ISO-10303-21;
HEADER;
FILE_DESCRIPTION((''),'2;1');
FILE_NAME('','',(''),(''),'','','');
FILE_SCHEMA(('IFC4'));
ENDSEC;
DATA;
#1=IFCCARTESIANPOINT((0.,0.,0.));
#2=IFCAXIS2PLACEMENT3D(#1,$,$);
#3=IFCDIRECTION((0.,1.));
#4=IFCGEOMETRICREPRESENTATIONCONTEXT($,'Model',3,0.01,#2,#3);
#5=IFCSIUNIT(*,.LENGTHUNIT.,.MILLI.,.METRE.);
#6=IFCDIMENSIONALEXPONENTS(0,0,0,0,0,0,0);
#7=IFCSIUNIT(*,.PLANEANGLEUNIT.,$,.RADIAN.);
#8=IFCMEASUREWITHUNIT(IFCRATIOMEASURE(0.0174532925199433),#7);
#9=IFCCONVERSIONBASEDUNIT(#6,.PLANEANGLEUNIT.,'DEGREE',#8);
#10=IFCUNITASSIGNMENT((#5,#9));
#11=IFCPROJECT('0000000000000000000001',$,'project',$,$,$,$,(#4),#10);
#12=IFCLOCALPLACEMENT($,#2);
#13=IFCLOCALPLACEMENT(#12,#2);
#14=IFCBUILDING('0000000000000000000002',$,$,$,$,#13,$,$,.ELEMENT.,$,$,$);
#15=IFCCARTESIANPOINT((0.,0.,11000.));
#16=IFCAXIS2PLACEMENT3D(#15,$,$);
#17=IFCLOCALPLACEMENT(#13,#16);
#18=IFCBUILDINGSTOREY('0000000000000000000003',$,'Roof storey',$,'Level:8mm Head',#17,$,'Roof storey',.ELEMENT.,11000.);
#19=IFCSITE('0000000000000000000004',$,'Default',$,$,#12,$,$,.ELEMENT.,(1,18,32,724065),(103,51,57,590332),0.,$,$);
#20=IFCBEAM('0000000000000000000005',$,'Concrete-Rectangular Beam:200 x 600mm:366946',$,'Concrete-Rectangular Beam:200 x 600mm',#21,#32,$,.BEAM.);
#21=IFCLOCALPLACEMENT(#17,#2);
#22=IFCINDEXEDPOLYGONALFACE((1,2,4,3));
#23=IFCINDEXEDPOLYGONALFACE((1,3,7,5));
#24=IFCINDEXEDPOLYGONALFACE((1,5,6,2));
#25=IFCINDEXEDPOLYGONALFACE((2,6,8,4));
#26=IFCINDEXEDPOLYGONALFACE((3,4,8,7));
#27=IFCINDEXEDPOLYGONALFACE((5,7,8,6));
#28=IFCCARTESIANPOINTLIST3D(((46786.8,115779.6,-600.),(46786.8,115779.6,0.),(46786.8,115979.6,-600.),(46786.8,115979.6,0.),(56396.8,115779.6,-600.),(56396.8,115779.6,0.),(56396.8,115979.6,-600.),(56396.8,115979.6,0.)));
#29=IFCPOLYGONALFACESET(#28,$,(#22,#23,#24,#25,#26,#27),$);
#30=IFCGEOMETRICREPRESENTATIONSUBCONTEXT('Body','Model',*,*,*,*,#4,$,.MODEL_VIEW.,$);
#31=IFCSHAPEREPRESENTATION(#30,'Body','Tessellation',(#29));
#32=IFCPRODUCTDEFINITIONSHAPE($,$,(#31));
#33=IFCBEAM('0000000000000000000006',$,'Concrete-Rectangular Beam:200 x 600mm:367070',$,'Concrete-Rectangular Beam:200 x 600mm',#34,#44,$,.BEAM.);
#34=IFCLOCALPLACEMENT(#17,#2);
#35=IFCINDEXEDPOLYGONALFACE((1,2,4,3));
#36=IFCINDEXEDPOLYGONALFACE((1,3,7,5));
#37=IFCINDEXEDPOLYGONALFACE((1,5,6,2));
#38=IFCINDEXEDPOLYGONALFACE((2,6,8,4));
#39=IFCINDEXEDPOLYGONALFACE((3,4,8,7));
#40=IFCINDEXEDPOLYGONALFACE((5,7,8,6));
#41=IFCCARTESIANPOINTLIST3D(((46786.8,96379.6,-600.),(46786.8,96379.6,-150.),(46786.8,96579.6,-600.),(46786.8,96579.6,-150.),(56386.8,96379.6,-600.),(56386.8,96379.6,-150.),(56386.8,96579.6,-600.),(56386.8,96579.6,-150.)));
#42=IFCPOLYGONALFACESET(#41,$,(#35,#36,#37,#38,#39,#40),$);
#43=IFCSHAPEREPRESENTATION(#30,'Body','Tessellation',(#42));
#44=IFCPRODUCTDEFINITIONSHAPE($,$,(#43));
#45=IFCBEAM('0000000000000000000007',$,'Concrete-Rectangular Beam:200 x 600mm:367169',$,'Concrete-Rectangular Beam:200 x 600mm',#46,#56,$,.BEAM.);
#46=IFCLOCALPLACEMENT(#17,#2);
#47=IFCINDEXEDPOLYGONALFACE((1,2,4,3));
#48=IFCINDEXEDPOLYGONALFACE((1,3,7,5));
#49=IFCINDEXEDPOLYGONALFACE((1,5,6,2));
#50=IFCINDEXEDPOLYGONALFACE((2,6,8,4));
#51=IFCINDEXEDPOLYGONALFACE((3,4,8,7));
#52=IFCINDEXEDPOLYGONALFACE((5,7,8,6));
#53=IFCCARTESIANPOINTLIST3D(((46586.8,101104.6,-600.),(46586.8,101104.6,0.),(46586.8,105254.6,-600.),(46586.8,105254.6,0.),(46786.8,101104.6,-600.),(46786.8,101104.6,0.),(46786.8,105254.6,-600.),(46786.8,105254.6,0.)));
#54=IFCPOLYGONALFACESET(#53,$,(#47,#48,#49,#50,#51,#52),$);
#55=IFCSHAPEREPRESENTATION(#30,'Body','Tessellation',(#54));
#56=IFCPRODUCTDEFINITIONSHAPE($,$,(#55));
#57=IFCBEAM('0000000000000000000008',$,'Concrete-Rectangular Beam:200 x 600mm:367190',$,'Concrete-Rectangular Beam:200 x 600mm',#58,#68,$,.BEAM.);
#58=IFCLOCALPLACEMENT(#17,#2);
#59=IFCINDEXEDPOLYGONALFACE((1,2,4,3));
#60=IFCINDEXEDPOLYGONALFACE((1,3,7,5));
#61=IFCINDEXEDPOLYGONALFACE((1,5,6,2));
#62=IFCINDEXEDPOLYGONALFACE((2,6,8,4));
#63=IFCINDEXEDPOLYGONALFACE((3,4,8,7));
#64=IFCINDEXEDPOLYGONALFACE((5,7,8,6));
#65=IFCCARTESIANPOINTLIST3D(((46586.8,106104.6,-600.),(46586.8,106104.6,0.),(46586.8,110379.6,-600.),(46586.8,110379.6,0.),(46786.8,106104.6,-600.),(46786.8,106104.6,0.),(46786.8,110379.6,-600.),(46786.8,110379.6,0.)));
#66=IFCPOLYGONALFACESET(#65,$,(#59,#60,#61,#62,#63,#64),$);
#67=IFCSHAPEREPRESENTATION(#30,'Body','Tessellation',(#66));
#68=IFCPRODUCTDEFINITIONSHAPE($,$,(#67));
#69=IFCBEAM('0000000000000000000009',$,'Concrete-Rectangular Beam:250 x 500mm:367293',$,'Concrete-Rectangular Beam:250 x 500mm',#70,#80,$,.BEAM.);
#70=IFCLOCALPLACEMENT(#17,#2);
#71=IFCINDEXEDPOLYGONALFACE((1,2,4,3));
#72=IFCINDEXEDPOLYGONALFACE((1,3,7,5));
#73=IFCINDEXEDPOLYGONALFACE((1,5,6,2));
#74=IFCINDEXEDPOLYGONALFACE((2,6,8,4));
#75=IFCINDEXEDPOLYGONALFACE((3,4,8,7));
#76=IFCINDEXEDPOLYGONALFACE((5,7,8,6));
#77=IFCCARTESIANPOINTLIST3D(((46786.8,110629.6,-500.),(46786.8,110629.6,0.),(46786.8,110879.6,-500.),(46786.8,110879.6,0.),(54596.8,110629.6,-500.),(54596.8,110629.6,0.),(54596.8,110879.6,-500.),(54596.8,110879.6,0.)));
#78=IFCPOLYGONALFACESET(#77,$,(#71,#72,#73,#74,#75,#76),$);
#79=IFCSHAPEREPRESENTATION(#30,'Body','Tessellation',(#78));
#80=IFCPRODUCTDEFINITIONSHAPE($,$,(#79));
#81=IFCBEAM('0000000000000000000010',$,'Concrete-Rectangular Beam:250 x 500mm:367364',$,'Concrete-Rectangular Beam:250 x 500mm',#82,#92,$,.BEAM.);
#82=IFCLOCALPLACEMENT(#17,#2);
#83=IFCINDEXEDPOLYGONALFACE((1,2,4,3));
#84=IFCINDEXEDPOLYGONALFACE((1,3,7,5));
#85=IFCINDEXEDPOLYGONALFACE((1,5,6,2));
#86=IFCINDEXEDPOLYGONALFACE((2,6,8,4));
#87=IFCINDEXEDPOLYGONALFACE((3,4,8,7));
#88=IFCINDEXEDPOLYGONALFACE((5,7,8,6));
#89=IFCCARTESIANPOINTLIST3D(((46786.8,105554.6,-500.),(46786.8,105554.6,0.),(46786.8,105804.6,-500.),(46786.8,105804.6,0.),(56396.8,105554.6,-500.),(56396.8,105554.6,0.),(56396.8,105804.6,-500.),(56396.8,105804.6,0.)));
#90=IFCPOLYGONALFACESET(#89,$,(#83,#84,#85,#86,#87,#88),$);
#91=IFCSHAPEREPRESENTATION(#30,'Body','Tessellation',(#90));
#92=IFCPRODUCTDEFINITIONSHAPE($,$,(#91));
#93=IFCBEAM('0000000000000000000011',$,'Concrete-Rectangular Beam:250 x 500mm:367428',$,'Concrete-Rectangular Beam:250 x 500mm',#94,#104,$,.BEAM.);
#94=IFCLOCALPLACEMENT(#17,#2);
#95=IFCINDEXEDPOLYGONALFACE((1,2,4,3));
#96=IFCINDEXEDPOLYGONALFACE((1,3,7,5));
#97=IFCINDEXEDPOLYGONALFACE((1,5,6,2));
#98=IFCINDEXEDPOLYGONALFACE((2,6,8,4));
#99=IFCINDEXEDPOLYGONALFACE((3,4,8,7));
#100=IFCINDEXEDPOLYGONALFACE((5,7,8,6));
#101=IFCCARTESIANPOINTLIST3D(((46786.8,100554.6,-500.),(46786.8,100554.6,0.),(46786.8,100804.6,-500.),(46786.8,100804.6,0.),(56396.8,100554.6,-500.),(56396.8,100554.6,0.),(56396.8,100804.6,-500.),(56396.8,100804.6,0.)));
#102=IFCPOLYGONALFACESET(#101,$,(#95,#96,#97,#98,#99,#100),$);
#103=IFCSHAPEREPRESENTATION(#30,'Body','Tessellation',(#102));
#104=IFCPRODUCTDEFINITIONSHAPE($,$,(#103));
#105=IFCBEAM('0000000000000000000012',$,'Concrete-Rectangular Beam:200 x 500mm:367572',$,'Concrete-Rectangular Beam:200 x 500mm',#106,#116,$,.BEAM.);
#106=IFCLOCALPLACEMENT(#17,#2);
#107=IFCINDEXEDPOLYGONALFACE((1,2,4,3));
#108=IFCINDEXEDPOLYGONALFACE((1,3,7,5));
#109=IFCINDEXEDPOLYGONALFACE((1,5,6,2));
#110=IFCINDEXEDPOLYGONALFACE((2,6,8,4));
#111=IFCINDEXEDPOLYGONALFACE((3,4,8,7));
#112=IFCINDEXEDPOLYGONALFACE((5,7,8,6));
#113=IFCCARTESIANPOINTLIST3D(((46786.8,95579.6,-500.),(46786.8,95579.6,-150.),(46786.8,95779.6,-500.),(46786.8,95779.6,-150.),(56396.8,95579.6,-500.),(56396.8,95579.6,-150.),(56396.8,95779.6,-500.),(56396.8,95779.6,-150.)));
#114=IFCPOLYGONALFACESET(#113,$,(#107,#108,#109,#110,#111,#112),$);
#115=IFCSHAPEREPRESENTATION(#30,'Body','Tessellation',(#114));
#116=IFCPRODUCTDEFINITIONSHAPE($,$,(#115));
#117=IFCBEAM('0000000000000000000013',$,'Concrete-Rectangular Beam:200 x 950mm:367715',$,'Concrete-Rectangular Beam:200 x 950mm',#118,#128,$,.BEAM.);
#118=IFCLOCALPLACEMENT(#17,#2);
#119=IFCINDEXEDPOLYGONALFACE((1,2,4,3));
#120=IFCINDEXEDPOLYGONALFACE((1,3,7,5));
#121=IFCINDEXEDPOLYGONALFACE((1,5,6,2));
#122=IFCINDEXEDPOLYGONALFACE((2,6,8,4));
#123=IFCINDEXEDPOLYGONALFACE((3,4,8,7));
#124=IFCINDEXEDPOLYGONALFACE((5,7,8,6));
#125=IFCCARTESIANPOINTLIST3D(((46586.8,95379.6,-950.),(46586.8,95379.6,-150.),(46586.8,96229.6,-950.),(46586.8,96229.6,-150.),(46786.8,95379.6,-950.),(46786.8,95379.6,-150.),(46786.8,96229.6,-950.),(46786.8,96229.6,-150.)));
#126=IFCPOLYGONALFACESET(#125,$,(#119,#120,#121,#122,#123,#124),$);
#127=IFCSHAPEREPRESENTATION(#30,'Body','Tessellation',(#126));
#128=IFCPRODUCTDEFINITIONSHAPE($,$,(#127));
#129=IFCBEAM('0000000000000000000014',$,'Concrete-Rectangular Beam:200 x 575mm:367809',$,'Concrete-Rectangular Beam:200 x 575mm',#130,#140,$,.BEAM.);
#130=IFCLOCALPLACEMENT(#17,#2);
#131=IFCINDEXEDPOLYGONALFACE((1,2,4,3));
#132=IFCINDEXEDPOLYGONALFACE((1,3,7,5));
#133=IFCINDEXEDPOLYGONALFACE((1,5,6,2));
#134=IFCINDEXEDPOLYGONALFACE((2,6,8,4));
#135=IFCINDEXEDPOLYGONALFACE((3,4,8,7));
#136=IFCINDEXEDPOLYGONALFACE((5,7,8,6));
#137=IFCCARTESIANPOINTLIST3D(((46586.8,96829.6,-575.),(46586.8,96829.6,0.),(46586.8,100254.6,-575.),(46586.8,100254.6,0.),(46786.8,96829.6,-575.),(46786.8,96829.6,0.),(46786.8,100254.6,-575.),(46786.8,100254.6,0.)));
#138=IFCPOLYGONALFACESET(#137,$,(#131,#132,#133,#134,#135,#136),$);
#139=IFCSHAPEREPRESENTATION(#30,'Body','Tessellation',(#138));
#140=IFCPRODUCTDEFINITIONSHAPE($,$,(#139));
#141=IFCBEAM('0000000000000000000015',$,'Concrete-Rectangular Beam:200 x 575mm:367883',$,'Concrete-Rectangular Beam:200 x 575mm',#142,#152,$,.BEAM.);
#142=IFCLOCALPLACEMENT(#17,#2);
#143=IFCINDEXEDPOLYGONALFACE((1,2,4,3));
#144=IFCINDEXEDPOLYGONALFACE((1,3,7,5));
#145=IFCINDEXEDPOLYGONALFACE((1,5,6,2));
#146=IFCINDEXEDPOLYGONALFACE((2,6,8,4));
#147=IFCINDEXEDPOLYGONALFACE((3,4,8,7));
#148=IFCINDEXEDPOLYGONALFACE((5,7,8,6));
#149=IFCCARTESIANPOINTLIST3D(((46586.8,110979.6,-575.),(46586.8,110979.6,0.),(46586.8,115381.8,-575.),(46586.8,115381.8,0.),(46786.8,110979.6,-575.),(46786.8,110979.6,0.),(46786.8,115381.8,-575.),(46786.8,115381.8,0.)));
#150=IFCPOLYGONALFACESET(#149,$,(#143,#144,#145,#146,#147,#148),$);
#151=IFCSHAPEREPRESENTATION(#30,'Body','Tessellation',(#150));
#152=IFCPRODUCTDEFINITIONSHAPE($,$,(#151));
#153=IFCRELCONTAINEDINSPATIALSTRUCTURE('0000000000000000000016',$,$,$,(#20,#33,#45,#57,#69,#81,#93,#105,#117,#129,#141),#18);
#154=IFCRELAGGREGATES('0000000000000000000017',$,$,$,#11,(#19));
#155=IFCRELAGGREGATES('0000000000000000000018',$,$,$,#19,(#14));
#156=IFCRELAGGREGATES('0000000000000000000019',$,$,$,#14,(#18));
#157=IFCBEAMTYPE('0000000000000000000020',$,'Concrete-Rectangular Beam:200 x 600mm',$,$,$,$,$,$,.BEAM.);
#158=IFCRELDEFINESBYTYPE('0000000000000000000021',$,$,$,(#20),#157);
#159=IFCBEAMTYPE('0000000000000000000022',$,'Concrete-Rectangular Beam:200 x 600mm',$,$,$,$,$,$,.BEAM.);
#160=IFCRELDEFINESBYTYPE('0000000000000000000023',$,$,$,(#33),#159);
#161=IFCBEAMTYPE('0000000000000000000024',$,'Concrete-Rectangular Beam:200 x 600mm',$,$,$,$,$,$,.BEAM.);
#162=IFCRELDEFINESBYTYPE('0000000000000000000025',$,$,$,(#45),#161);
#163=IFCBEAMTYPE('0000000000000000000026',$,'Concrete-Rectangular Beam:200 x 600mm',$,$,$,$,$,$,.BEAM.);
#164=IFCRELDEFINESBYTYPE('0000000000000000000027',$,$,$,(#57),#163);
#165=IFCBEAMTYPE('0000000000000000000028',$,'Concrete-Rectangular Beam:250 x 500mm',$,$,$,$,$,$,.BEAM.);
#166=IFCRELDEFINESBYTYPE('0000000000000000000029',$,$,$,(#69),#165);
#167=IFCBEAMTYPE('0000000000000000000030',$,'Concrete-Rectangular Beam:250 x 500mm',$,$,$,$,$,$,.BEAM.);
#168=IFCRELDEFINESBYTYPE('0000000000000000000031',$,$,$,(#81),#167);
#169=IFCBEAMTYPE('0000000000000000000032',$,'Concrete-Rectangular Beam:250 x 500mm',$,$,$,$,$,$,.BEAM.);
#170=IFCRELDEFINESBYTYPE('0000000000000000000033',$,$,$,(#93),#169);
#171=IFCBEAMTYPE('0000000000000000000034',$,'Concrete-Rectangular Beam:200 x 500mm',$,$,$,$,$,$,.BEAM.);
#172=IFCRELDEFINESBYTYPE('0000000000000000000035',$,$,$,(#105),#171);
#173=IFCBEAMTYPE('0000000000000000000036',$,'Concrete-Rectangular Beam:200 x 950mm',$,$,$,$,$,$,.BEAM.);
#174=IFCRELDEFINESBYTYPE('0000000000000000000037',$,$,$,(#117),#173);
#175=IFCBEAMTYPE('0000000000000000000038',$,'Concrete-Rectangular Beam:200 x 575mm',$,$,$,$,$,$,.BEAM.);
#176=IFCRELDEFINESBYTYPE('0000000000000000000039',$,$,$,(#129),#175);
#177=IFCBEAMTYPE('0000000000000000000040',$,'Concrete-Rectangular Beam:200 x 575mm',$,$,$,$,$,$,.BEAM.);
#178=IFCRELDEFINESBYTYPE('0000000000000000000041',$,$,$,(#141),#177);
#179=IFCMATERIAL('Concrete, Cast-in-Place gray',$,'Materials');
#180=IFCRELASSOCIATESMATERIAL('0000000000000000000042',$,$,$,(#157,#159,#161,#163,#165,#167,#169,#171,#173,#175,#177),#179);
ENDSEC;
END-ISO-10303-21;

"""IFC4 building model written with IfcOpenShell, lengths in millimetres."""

from ifc_helpers import new_model, entity, si_unit, converted_unit, direction, frame, origin, place, context, subcontext, project, spatial, indexed_curve, outline, extrude, source, transform, mapped, material, type_object, type_shapes, element, save


model = new_model("IFC4")

# Units and contexts
model_context = context("Model", 3, precision=0.01, world=origin(), true_north=direction((0.0, 1.0)))
body_context = subcontext(model_context, "Body", "Model", "MODEL_VIEW")
ifc_project = project(units=[si_unit("LENGTHUNIT", "METRE", prefix="MILLI"), converted_unit("PLANEANGLEUNIT", "DEGREE", entity("IfcRatioMeasure", 0.0174532925199433), si_unit("PLANEANGLEUNIT", "RADIAN"), dimensions=[0, 0, 0, 0, 0, 0, 0])], contexts=[model_context])

# Site, building, storey
site_placement = place(None, origin())
site = spatial("IfcSite", under=ifc_project, at=site_placement, Name="Default", CompositionType="ELEMENT", RefLatitude=(1, 18, 32, 724065), RefLongitude=(103, 51, 57, 590332), RefElevation=0.0)
building_placement = place(site_placement, origin())
building = spatial("IfcBuilding", under=site, at=building_placement, CompositionType="ELEMENT")
storey_placement = place(building_placement, frame((0.0, 0.0, 11000.0)))
storey = spatial("IfcBuildingStorey", under=building, at=storey_placement, Name="Roof storey", ObjectType="Level:8mm Head", LongName="Roof storey", CompositionType="ELEMENT", Elevation=11000.0)

# Beams
ifc_material_1 = material(Name="Concrete, Cast-in-Place gray", Category="Materials")
beam_type_1 = type_object("IfcBeamType", Name="Concrete-Rectangular Beam:200 x 600mm", PredefinedType="BEAM", material=ifc_material_1)
shared_shape_1 = source(origin(), body_context, "Body", "SweptSolid", [
    extrude(outline(indexed_curve([(-300.0, -100.0), (300.0, -100.0), (300.0, 100.0), (-300.0, 100.0), (-300.0, -100.0)], self_intersect=False)), frame((46786.8, 115879.6, 10700.0), z_axis=(1.0, 0.0, 0.0), x_axis=(0.0, 0.0, -1.0)), (0.0, 0.0, 1.0), 9610.0),
])
type_shapes(beam_type_1, [shared_shape_1])
beam_1_placement = place(storey_placement, frame((0.0, 0.0, -11000.0)))
element("IfcBeam", 1, at=beam_1_placement, inside=storey, type_object=beam_type_1, Name="Concrete-Rectangular Beam:200 x 600mm:366946", ObjectType="Concrete-Rectangular Beam:200 x 600mm", PredefinedType="BEAM", context=body_context, shape_type="MappedRepresentation", body=[
    mapped(shared_shape_1, transform((0.0, 0.0, 0.0), scale=1.0)),
])
beam_type_2 = type_object("IfcBeamType", Name="Concrete-Rectangular Beam:200 x 600mm", PredefinedType="BEAM", material=ifc_material_1)
shared_shape_2 = source(origin(), body_context, "Body", "SweptSolid", [
    extrude(outline(indexed_curve([(-225.0, -100.0), (225.0, -100.0), (225.0, 100.0), (-225.0, 100.0), (-225.0, -100.0)], self_intersect=False)), frame((46786.8, 96479.6, 10625.0), z_axis=(1.0, 0.0, 0.0), x_axis=(0.0, 0.0, -1.0)), (0.0, 0.0, 1.0), 9600.0),
])
type_shapes(beam_type_2, [shared_shape_2])
beam_2_placement = place(storey_placement, frame((0.0, 0.0, -11000.0)))
element("IfcBeam", 2, at=beam_2_placement, inside=storey, type_object=beam_type_2, Name="Concrete-Rectangular Beam:200 x 600mm:367070", ObjectType="Concrete-Rectangular Beam:200 x 600mm", PredefinedType="BEAM", context=body_context, shape_type="MappedRepresentation", body=[
    mapped(shared_shape_2, transform((0.0, 0.0, 0.0), scale=1.0)),
])
beam_type_3 = type_object("IfcBeamType", Name="Concrete-Rectangular Beam:200 x 600mm", PredefinedType="BEAM", material=ifc_material_1)
shared_shape_3 = source(origin(), body_context, "Body", "SweptSolid", [
    extrude(outline(indexed_curve([(-100.0, -300.0), (100.0, -300.0), (100.0, 300.0), (-100.0, 300.0), (-100.0, -300.0)], self_intersect=False)), frame((46686.8, 101104.6, 10700.0), z_axis=(0.0, 1.0, 0.0), x_axis=(-1.0, 0.0, 0.0)), (0.0, 0.0, 1.0), 4150.0),
])
type_shapes(beam_type_3, [shared_shape_3])
beam_3_placement = place(storey_placement, frame((0.0, 0.0, -11000.0)))
element("IfcBeam", 3, at=beam_3_placement, inside=storey, type_object=beam_type_3, Name="Concrete-Rectangular Beam:200 x 600mm:367169", ObjectType="Concrete-Rectangular Beam:200 x 600mm", PredefinedType="BEAM", context=body_context, shape_type="MappedRepresentation", body=[
    mapped(shared_shape_3, transform((0.0, 0.0, 0.0), scale=1.0)),
])
beam_type_4 = type_object("IfcBeamType", Name="Concrete-Rectangular Beam:200 x 600mm", PredefinedType="BEAM", material=ifc_material_1)
shared_shape_4 = source(origin(), body_context, "Body", "SweptSolid", [
    extrude(outline(indexed_curve([(-100.0, -300.0), (100.0, -300.0), (100.0, 300.0), (-100.0, 300.0), (-100.0, -300.0)], self_intersect=False)), frame((46686.8, 106104.6, 10700.0), z_axis=(0.0, 1.0, 0.0), x_axis=(-1.0, 0.0, 0.0)), (0.0, 0.0, 1.0), 4275.0),
])
type_shapes(beam_type_4, [shared_shape_4])
beam_4_placement = place(storey_placement, frame((0.0, 0.0, -11000.0)))
element("IfcBeam", 4, at=beam_4_placement, inside=storey, type_object=beam_type_4, Name="Concrete-Rectangular Beam:200 x 600mm:367190", ObjectType="Concrete-Rectangular Beam:200 x 600mm", PredefinedType="BEAM", context=body_context, shape_type="MappedRepresentation", body=[
    mapped(shared_shape_4, transform((0.0, 0.0, 0.0), scale=1.0)),
])
beam_type_5 = type_object("IfcBeamType", Name="Concrete-Rectangular Beam:250 x 500mm", PredefinedType="BEAM", material=ifc_material_1)
shared_shape_5 = source(origin(), body_context, "Body", "SweptSolid", [
    extrude(outline(indexed_curve([(-250.0, -125.0), (250.0, -125.0), (250.0, 125.0), (-250.0, 125.0), (-250.0, -125.0)], self_intersect=False)), frame((46786.8, 110754.6, 10750.0), z_axis=(1.0, 0.0, 0.0), x_axis=(0.0, 0.0, -1.0)), (0.0, 0.0, 1.0), 7810.0),
])
type_shapes(beam_type_5, [shared_shape_5])
beam_5_placement = place(storey_placement, frame((0.0, 0.0, -11000.0)))
element("IfcBeam", 5, at=beam_5_placement, inside=storey, type_object=beam_type_5, Name="Concrete-Rectangular Beam:250 x 500mm:367293", ObjectType="Concrete-Rectangular Beam:250 x 500mm", PredefinedType="BEAM", context=body_context, shape_type="MappedRepresentation", body=[
    mapped(shared_shape_5, transform((0.0, 0.0, 0.0), scale=1.0)),
])
beam_type_6 = type_object("IfcBeamType", Name="Concrete-Rectangular Beam:250 x 500mm", PredefinedType="BEAM", material=ifc_material_1)
shared_shape_6 = source(origin(), body_context, "Body", "SweptSolid", [
    extrude(outline(indexed_curve([(-250.0, -125.0), (250.0, -125.0), (250.0, 125.0), (-250.0, 125.0), (-250.0, -125.0)], self_intersect=False)), frame((46786.8, 105679.6, 10750.0), z_axis=(1.0, 0.0, 0.0), x_axis=(0.0, 0.0, -1.0)), (0.0, 0.0, 1.0), 9610.0),
])
type_shapes(beam_type_6, [shared_shape_6])
beam_6_placement = place(storey_placement, frame((0.0, 0.0, -11000.0)))
element("IfcBeam", 6, at=beam_6_placement, inside=storey, type_object=beam_type_6, Name="Concrete-Rectangular Beam:250 x 500mm:367364", ObjectType="Concrete-Rectangular Beam:250 x 500mm", PredefinedType="BEAM", context=body_context, shape_type="MappedRepresentation", body=[
    mapped(shared_shape_6, transform((0.0, 0.0, 0.0), scale=1.0)),
])
beam_type_7 = type_object("IfcBeamType", Name="Concrete-Rectangular Beam:250 x 500mm", PredefinedType="BEAM", material=ifc_material_1)
shared_shape_7 = source(origin(), body_context, "Body", "SweptSolid", [
    extrude(outline(indexed_curve([(-250.0, -125.0), (250.0, -125.0), (250.0, 125.0), (-250.0, 125.0), (-250.0, -125.0)], self_intersect=False)), frame((46786.8, 100679.6, 10750.0), z_axis=(1.0, 0.0, 0.0), x_axis=(0.0, 0.0, -1.0)), (0.0, 0.0, 1.0), 9610.0),
])
type_shapes(beam_type_7, [shared_shape_7])
beam_7_placement = place(storey_placement, frame((0.0, 0.0, -11000.0)))
element("IfcBeam", 7, at=beam_7_placement, inside=storey, type_object=beam_type_7, Name="Concrete-Rectangular Beam:250 x 500mm:367428", ObjectType="Concrete-Rectangular Beam:250 x 500mm", PredefinedType="BEAM", context=body_context, shape_type="MappedRepresentation", body=[
    mapped(shared_shape_7, transform((0.0, 0.0, 0.0), scale=1.0)),
])
beam_type_8 = type_object("IfcBeamType", Name="Concrete-Rectangular Beam:200 x 500mm", PredefinedType="BEAM", material=ifc_material_1)
shared_shape_8 = source(origin(), body_context, "Body", "SweptSolid", [
    extrude(outline(indexed_curve([(-175.0, -100.0), (175.0, -100.0), (175.0, 100.0), (-175.0, 100.0), (-175.0, -100.0)], self_intersect=False)), frame((46786.8, 95679.6, 10675.0), z_axis=(1.0, 0.0, 0.0), x_axis=(0.0, 0.0, -1.0)), (0.0, 0.0, 1.0), 9610.0),
])
type_shapes(beam_type_8, [shared_shape_8])
beam_8_placement = place(storey_placement, frame((0.0, 0.0, -11000.0)))
element("IfcBeam", 8, at=beam_8_placement, inside=storey, type_object=beam_type_8, Name="Concrete-Rectangular Beam:200 x 500mm:367572", ObjectType="Concrete-Rectangular Beam:200 x 500mm", PredefinedType="BEAM", context=body_context, shape_type="MappedRepresentation", body=[
    mapped(shared_shape_8, transform((0.0, 0.0, 0.0), scale=1.0)),
])
beam_type_9 = type_object("IfcBeamType", Name="Concrete-Rectangular Beam:200 x 950mm", PredefinedType="BEAM", material=ifc_material_1)
shared_shape_9 = source(origin(), body_context, "Body", "SweptSolid", [
    extrude(outline(indexed_curve([(-100.0, -400.0), (100.0, -400.0), (100.0, 400.0), (-100.0, 400.0), (-100.0, -400.0)], self_intersect=False)), frame((46686.8, 95379.6, 10450.0), z_axis=(0.0, 1.0, 0.0), x_axis=(-1.0, 0.0, 0.0)), (0.0, 0.0, 1.0), 850.0),
])
type_shapes(beam_type_9, [shared_shape_9])
beam_9_placement = place(storey_placement, frame((0.0, 0.0, -11000.0)))
element("IfcBeam", 9, at=beam_9_placement, inside=storey, type_object=beam_type_9, Name="Concrete-Rectangular Beam:200 x 950mm:367715", ObjectType="Concrete-Rectangular Beam:200 x 950mm", PredefinedType="BEAM", context=body_context, shape_type="MappedRepresentation", body=[
    mapped(shared_shape_9, transform((0.0, 0.0, 0.0), scale=1.0)),
])
beam_type_10 = type_object("IfcBeamType", Name="Concrete-Rectangular Beam:200 x 575mm", PredefinedType="BEAM", material=ifc_material_1)
shared_shape_10 = source(origin(), body_context, "Body", "SweptSolid", [
    extrude(outline(indexed_curve([(-100.0, -287.5), (100.0, -287.5), (100.0, 287.5), (-100.0, 287.5), (-100.0, -287.5)], self_intersect=False)), frame((46686.8, 96829.6, 10712.5), z_axis=(0.0, 1.0, 0.0), x_axis=(-1.0, 0.0, 0.0)), (0.0, 0.0, 1.0), 3425.0),
])
type_shapes(beam_type_10, [shared_shape_10])
beam_10_placement = place(storey_placement, frame((0.0, 0.0, -11000.0)))
element("IfcBeam", 10, at=beam_10_placement, inside=storey, type_object=beam_type_10, Name="Concrete-Rectangular Beam:200 x 575mm:367809", ObjectType="Concrete-Rectangular Beam:200 x 575mm", PredefinedType="BEAM", context=body_context, shape_type="MappedRepresentation", body=[
    mapped(shared_shape_10, transform((0.0, 0.0, 0.0), scale=1.0)),
])
beam_type_11 = type_object("IfcBeamType", Name="Concrete-Rectangular Beam:200 x 575mm", PredefinedType="BEAM", material=ifc_material_1)
shared_shape_11 = source(origin(), body_context, "Body", "SweptSolid", [
    extrude(outline(indexed_curve([(-100.0, -287.5), (100.0, -287.5), (100.0, 287.5), (-100.0, 287.5), (-100.0, -287.5)], self_intersect=False)), frame((46686.8, 110979.6, 10712.5), z_axis=(0.0, 1.0, 0.0), x_axis=(-1.0, 0.0, 0.0)), (0.0, 0.0, 1.0), 4402.2),
])
type_shapes(beam_type_11, [shared_shape_11])
beam_11_placement = place(storey_placement, frame((0.0, 0.0, -11000.0)))
element("IfcBeam", 11, at=beam_11_placement, inside=storey, type_object=beam_type_11, Name="Concrete-Rectangular Beam:200 x 575mm:367883", ObjectType="Concrete-Rectangular Beam:200 x 575mm", PredefinedType="BEAM", context=body_context, shape_type="MappedRepresentation", body=[
    mapped(shared_shape_11, transform((0.0, 0.0, 0.0), scale=1.0)),
])

save(model, "model.ifc")
